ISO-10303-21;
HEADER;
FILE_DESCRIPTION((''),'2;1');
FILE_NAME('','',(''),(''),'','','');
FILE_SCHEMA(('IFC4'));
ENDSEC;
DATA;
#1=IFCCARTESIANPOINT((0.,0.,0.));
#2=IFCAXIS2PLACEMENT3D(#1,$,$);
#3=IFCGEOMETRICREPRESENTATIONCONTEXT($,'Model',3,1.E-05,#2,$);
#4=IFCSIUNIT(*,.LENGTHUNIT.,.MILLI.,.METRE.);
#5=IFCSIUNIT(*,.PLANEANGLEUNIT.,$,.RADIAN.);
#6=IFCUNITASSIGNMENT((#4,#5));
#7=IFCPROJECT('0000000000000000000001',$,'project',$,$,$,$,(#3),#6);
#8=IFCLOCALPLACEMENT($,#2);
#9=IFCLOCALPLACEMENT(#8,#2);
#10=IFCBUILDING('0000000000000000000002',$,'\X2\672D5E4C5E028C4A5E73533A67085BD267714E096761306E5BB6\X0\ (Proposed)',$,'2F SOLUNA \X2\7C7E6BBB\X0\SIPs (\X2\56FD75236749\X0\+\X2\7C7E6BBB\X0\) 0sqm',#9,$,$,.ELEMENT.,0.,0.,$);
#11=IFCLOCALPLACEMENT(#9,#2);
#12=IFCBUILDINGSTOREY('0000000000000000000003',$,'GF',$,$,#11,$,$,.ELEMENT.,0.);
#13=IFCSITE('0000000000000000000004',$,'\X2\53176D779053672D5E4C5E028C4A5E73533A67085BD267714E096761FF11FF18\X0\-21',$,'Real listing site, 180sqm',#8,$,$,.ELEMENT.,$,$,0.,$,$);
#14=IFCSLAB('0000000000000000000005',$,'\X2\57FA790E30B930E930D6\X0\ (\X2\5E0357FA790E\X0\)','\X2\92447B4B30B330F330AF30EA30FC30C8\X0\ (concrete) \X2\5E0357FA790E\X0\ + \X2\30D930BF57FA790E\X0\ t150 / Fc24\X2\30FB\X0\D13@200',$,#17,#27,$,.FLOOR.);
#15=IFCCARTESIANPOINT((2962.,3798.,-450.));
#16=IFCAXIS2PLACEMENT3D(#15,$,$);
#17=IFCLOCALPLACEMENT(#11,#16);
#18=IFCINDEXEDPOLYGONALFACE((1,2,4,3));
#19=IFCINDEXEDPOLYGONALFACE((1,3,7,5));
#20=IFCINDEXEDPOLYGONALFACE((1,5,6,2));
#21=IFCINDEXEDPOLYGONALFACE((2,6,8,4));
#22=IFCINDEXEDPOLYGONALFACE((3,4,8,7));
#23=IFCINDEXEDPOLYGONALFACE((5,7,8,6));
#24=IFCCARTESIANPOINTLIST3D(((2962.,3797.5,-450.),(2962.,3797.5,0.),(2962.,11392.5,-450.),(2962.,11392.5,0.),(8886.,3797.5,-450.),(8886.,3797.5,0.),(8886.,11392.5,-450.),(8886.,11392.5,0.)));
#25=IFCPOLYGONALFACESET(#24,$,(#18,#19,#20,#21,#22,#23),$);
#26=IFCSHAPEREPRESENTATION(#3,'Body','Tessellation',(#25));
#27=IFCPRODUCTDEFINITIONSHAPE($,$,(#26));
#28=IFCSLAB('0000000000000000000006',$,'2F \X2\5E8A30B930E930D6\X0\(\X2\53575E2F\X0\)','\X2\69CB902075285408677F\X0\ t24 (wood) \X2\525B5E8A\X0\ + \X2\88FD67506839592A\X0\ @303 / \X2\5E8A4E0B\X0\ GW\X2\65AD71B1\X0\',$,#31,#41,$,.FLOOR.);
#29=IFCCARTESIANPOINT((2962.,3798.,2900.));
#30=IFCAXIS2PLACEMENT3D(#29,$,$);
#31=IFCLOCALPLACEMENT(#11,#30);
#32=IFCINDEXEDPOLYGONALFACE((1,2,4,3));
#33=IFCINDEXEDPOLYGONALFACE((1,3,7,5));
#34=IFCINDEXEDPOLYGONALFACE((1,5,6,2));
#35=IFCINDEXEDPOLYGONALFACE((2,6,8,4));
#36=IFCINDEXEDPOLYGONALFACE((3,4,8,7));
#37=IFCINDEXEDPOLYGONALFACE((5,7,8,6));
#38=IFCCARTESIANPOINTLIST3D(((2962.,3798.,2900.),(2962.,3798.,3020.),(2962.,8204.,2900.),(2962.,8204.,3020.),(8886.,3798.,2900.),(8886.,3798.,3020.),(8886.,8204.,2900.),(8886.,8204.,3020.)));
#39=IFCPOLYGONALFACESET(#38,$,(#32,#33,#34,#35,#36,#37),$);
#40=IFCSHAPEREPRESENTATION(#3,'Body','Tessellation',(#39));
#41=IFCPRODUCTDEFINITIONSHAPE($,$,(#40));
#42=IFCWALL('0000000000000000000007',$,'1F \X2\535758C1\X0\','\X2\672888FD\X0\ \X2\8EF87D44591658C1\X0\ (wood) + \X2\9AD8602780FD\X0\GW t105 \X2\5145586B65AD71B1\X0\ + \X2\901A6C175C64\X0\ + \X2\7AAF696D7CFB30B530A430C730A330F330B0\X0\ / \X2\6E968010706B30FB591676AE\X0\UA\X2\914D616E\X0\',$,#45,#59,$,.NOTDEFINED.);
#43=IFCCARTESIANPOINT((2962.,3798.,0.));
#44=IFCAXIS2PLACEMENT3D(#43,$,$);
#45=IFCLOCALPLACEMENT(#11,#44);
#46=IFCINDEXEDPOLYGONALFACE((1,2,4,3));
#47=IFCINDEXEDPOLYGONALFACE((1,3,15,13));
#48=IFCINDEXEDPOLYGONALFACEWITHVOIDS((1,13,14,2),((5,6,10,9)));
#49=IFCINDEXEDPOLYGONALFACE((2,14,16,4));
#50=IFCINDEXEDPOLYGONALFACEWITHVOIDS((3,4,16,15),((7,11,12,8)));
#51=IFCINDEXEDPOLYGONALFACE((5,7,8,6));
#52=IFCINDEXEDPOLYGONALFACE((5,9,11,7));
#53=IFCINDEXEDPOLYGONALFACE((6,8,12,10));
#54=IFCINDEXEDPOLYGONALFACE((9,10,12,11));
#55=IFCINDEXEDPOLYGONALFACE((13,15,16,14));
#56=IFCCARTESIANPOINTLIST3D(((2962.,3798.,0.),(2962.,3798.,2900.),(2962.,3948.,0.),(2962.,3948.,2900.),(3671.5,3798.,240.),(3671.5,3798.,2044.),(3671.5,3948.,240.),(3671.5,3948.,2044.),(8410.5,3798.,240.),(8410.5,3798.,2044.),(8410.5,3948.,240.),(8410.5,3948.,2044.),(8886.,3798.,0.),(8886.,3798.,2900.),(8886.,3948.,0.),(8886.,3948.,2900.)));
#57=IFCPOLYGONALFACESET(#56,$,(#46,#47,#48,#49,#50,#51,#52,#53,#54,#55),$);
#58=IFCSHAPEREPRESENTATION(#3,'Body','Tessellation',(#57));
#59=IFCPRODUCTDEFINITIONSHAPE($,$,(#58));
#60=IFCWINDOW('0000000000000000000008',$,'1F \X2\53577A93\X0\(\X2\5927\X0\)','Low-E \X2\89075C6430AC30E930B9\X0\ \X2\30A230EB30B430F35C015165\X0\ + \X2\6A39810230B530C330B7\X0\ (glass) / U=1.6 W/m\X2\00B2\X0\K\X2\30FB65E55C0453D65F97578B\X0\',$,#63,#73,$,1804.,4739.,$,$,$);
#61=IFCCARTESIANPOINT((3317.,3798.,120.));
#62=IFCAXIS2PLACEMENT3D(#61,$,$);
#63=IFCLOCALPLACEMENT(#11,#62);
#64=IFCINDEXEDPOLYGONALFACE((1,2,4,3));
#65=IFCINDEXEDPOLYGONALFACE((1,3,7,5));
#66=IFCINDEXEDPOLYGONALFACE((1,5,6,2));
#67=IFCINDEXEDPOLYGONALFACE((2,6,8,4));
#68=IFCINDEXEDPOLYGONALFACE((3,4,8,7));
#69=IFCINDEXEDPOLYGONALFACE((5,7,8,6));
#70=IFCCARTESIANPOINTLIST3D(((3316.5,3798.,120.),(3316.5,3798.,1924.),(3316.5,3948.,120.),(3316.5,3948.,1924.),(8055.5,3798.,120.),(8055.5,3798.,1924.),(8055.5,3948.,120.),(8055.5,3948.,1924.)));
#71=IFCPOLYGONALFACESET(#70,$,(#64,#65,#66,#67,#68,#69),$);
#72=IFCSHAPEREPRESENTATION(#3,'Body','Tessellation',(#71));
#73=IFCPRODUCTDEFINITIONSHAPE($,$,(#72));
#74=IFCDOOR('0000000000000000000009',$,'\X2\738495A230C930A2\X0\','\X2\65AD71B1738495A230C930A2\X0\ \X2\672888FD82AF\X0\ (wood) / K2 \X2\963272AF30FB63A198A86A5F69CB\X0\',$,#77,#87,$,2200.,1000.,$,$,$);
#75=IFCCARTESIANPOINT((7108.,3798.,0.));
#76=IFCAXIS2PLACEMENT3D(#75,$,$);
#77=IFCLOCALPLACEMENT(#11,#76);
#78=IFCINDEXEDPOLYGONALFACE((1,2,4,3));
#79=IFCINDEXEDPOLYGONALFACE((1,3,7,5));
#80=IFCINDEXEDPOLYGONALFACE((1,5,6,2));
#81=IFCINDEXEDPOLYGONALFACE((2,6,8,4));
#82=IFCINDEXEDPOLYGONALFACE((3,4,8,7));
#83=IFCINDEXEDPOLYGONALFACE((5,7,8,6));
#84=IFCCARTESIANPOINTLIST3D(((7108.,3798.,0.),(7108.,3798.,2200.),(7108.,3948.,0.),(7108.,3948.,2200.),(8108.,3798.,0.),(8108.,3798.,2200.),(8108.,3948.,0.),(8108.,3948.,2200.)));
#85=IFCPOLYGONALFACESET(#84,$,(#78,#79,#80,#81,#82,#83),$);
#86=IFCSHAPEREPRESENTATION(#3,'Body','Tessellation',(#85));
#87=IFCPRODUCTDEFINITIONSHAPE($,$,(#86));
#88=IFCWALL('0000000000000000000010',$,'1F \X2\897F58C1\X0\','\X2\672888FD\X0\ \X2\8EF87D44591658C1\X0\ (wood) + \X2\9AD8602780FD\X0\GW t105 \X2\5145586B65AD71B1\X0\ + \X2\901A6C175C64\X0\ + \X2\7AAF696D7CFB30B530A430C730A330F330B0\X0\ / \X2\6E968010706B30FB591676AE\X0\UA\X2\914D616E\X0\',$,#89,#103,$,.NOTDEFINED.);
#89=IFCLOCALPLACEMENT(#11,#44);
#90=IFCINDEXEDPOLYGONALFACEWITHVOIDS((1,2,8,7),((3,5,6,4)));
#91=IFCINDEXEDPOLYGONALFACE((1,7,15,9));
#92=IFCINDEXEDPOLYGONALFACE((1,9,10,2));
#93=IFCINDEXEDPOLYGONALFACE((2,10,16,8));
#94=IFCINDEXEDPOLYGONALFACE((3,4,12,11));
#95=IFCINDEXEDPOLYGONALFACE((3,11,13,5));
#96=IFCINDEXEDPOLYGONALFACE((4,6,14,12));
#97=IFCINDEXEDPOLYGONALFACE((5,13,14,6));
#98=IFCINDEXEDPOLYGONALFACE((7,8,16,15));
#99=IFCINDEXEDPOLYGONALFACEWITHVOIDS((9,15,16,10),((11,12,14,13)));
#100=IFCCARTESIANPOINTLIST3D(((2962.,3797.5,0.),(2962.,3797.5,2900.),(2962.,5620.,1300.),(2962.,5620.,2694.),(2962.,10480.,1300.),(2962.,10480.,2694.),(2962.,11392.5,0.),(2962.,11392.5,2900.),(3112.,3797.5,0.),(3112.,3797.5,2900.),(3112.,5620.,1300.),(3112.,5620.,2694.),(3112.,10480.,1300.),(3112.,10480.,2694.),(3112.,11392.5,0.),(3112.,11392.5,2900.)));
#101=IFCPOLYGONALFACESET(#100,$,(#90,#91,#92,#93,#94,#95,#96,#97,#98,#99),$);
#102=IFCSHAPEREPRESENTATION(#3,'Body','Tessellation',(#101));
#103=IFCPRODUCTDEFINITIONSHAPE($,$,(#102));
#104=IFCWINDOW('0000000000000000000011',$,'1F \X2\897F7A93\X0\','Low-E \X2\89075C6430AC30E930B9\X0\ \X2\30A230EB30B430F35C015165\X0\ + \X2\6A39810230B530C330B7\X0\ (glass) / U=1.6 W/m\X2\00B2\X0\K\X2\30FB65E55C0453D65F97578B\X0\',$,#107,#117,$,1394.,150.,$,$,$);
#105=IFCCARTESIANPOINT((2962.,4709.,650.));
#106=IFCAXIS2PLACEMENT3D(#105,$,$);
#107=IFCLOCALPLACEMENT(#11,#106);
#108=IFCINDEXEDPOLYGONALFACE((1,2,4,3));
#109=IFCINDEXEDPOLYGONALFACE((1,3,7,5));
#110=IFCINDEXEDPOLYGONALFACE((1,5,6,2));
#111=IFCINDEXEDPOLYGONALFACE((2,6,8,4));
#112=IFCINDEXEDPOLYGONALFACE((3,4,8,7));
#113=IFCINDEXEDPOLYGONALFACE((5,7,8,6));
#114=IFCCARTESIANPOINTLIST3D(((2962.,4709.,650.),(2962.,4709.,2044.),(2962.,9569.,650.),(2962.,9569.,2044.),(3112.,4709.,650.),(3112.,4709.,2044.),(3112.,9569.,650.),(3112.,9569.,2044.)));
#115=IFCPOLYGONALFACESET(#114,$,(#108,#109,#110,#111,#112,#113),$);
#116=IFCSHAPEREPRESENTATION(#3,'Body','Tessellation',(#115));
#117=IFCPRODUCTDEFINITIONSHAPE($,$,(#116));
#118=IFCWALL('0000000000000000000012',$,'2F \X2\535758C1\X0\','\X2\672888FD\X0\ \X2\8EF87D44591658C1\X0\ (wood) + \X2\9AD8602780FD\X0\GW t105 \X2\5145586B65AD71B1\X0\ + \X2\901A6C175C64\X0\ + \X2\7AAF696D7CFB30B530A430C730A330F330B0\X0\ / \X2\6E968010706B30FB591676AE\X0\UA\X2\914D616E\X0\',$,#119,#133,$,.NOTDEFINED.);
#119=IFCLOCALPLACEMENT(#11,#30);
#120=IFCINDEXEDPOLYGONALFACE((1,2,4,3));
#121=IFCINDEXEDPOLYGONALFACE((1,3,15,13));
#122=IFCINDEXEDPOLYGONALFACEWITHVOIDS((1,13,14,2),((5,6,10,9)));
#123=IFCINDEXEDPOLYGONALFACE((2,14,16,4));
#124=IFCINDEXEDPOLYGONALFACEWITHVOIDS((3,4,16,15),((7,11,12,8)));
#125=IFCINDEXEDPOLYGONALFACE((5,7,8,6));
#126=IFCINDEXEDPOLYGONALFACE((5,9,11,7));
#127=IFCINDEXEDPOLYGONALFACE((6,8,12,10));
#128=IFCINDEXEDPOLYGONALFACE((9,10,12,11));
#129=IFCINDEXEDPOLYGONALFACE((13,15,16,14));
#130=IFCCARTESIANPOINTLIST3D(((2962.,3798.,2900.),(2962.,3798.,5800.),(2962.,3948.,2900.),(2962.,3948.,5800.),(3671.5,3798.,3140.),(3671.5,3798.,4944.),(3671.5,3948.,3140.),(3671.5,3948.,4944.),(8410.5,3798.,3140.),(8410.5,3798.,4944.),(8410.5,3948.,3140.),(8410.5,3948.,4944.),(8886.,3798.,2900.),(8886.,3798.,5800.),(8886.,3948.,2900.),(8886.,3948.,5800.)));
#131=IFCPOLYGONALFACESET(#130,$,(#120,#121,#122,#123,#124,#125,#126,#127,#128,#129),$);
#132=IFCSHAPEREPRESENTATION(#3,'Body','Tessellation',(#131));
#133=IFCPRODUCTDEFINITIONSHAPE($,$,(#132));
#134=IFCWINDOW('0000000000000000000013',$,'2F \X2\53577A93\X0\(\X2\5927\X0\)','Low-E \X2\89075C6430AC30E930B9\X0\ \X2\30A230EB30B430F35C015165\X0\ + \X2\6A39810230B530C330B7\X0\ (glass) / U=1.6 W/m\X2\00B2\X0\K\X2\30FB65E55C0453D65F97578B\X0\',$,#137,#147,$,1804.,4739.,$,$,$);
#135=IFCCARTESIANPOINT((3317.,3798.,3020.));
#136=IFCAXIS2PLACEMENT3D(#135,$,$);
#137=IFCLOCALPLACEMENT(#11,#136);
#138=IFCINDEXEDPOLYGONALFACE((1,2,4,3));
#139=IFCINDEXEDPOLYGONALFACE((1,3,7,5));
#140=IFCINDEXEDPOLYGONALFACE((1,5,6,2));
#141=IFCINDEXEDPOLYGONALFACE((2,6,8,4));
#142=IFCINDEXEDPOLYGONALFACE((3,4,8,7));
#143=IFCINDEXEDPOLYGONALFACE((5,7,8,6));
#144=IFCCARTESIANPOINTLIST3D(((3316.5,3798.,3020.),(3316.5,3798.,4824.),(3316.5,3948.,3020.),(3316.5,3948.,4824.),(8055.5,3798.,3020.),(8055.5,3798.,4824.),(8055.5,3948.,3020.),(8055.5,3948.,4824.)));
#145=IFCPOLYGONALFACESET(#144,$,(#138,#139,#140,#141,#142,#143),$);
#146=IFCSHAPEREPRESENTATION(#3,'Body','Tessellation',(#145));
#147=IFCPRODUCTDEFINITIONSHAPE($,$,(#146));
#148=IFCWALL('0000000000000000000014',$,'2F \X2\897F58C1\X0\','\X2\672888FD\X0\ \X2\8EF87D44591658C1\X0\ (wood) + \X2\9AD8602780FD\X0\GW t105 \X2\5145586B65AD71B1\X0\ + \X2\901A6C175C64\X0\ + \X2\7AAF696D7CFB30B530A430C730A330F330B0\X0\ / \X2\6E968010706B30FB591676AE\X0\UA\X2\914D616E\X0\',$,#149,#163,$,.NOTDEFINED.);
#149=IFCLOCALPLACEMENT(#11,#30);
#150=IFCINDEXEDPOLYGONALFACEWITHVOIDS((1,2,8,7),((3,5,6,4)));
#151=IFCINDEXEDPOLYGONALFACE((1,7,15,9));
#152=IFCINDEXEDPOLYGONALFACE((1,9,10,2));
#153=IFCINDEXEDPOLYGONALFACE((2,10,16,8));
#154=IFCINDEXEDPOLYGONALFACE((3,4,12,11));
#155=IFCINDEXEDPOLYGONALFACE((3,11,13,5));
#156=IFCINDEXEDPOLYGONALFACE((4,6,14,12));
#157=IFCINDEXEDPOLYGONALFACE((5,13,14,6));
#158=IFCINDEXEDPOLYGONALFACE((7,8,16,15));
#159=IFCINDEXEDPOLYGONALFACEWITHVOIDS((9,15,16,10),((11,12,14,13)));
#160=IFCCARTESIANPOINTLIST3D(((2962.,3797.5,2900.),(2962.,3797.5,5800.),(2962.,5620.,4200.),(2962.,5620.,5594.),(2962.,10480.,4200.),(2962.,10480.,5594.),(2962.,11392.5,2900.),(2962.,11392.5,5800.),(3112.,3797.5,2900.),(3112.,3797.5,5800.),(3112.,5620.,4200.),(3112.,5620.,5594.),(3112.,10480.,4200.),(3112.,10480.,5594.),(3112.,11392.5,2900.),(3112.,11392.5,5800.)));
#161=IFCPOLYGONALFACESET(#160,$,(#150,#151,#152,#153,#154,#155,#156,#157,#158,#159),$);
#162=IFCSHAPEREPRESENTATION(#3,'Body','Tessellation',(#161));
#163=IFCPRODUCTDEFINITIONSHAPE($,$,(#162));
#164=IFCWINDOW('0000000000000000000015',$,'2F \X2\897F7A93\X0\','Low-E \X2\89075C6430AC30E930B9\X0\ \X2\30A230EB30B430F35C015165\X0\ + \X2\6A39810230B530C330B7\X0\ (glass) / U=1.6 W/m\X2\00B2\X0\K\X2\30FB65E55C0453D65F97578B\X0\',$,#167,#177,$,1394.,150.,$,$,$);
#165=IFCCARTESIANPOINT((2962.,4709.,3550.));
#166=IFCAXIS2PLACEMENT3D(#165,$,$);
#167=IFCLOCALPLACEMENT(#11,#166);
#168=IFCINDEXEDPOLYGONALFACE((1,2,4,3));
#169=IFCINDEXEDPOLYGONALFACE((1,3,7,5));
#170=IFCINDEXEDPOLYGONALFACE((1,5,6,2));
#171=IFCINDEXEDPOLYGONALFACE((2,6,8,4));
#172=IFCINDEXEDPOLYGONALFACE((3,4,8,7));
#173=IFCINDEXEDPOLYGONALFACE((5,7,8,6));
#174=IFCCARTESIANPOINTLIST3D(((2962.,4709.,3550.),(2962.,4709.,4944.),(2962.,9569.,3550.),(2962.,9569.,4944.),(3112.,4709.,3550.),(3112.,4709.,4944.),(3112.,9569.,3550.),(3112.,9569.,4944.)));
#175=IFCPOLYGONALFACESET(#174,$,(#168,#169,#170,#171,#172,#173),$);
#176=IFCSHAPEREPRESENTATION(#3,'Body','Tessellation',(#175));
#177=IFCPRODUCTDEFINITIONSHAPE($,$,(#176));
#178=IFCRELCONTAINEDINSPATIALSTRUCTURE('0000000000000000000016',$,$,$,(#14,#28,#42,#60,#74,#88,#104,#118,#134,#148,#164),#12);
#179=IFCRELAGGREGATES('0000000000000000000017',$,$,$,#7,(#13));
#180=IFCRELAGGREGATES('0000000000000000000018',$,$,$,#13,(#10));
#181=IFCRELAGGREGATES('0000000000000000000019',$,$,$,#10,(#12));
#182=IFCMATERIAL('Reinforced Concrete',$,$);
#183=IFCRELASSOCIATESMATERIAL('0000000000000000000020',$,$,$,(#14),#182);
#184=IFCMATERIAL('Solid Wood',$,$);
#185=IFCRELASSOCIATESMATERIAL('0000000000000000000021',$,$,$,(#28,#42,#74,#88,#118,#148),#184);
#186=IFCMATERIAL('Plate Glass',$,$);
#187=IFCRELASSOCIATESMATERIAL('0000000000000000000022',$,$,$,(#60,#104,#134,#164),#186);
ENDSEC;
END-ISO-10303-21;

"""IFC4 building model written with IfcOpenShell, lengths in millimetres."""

from ifc_helpers import new_model, si_unit, frame, frame_2d, origin, place, context, project, spatial, rectangle, extrude, material, element, fill, save


model = new_model("IFC4")

# Units and contexts
model_context = context("Model", 3, precision=1e-05, world=origin())
ifc_project = project(units=[si_unit("LENGTHUNIT", "METRE", prefix="MILLI"), si_unit("PLANEANGLEUNIT", "RADIAN")], contexts=[model_context])

# Site, building, storey
site_placement = place(None, origin())
site = spatial("IfcSite", under=ifc_project, at=site_placement, Name="北海道札幌市豊平区月寒東三条１８-21", ObjectType="Real listing site, 180sqm", CompositionType="ELEMENT", RefElevation=0.0)
building_placement = place(site_placement, origin())
building = spatial("IfcBuilding", under=site, at=building_placement, Name="札幌市豊平区月寒東三条の家 (Proposed)", ObjectType="2F SOLUNA 籾殻SIPs (国産杉+籾殻) 0sqm", CompositionType="ELEMENT", ElevationOfRefHeight=0.0, ElevationOfTerrain=0.0)
storey_placement = place(building_placement, origin())
storey = spatial("IfcBuildingStorey", under=building, at=storey_placement, Name="GF", CompositionType="ELEMENT", Elevation=0.0)

# Slabs
ifc_material_1 = material(Name="Reinforced Concrete")
slab_1_placement = place(storey_placement, frame((2962.0, 3798.0, -450.0)))
element("IfcSlab", 1, at=slab_1_placement, inside=storey, material=ifc_material_1, Name="基礎スラブ (布基礎)", Description="鉄筋コンクリート (concrete) 布基礎 + ベタ基礎 t150 / Fc24・D13@200", PredefinedType="FLOOR", context=model_context, shape_type="SweptSolid", body=[
    extrude(rectangle(XDim=5924.0, YDim=7595.0, at=frame_2d((2962.0, 3797.0))), frame((2962.0, 3798.0, -450.0)), (0.0, 0.0, 1.0), 450.0),
])
ifc_material_2 = material(Name="Solid Wood")
slab_2_placement = place(storey_placement, frame((2962.0, 3798.0, 2900.0)))
element("IfcSlab", 2, at=slab_2_placement, inside=storey, material=ifc_material_2, Name="2F 床スラブ(南帯)", Description="構造用合板 t24 (wood) 剛床 + 製材根太 @303 / 床下 GW断熱", PredefinedType="FLOOR", context=model_context, shape_type="SweptSolid", body=[
    extrude(rectangle(XDim=5924.0, YDim=4406.0, at=frame_2d((2962.0, 2203.0))), frame((2962.0, 3798.0, 2900.0)), (0.0, 0.0, 1.0), 120.0),
])

# Wall, openings, window, door
wall_1_placement = place(storey_placement, frame((2962.0, 3798.0, 0.0)))
wall_1 = element("IfcWall", 3, at=wall_1_placement, inside=storey, material=ifc_material_2, Name="1F 南壁", Description="木製 軸組外壁 (wood) + 高性能GW t105 充填断熱 + 通気層 + 窯業系サイディング / 準耐火・外皮UA配慮", PredefinedType="NOTDEFINED", context=model_context, shape_type="SweptSolid", body=[
    extrude(rectangle(XDim=5924.0, YDim=150.0, at=frame_2d((2962.0, 75.0))), frame((2962.0, 3798.0, 0.0)), (0.0, 0.0, 1.0), 2900.0),
])
opening_1_placement = place(storey_placement, frame((3317.0, 3798.0, 120.0)))
opening_1 = element("IfcOpeningElement", 4, at=opening_1_placement, cuts=wall_1, PredefinedType="NOTDEFINED", context=model_context, shape_type="SweptSolid", body=[
    extrude(rectangle(XDim=4739.0, YDim=150.0, at=frame_2d((2369.0, 75.0))), frame((3317.0, 3798.0, 120.0)), (0.0, 0.0, 1.0), 1804.0),
])
opening_2_placement = place(storey_placement, frame((7108.0, 3798.0, 0.0)))
opening_2 = element("IfcOpeningElement", 5, at=opening_2_placement, cuts=wall_1, PredefinedType="NOTDEFINED", context=model_context, shape_type="SweptSolid", body=[
    extrude(rectangle(XDim=1000.0, YDim=150.0, at=frame_2d((500.0, 75.0))), frame((7108.0, 3798.0, 0.0)), (0.0, 0.0, 1.0), 2200.0),
])
ifc_material_3 = material(Name="Plate Glass")
window_1_placement = place(storey_placement, frame((3317.0, 3798.0, 120.0)))
window_1 = element("IfcWindow", 6, at=window_1_placement, inside=storey, material=ifc_material_3, Name="1F 南窓(大)", Description="Low-E 複層ガラス アルゴン封入 + 樹脂サッシ (glass) / U=1.6 W/m²K・日射取得型", OverallHeight=1804.0, OverallWidth=4739.0, context=model_context, shape_type="SweptSolid", body=[
    extrude(rectangle(XDim=4739.0, YDim=150.0, at=frame_2d((2369.0, 75.0))), frame((3317.0, 3798.0, 120.0)), (0.0, 0.0, 1.0), 1804.0),
])
fill(opening_1, window_1)
door_placement = place(storey_placement, frame((7108.0, 3798.0, 0.0)))
door = element("IfcDoor", 7, at=door_placement, inside=storey, material=ifc_material_2, Name="玄関ドア", Description="断熱玄関ドア 木製芯 (wood) / K2 防犯・採風機構", OverallHeight=2200.0, OverallWidth=1000.0, context=model_context, shape_type="SweptSolid", body=[
    extrude(rectangle(XDim=1000.0, YDim=150.0, at=frame_2d((500.0, 75.0))), frame((7108.0, 3798.0, 0.0)), (0.0, 0.0, 1.0), 2200.0),
])
fill(opening_2, door)

# Wall, opening, window
wall_2_placement = place(storey_placement, frame((2962.0, 3798.0, 0.0)))
wall_2 = element("IfcWall", 8, at=wall_2_placement, inside=storey, material=ifc_material_2, Name="1F 西壁", Description="木製 軸組外壁 (wood) + 高性能GW t105 充填断熱 + 通気層 + 窯業系サイディング / 準耐火・外皮UA配慮", PredefinedType="NOTDEFINED", context=model_context, shape_type="SweptSolid", body=[
    extrude(rectangle(XDim=150.0, YDim=7595.0, at=frame_2d((75.0, 3797.0))), frame((2962.0, 3798.0, 0.0)), (0.0, 0.0, 1.0), 2900.0),
])
opening_3_placement = place(storey_placement, frame((2962.0, 4709.0, 650.0)))
opening_3 = element("IfcOpeningElement", 9, at=opening_3_placement, cuts=wall_2, PredefinedType="NOTDEFINED", context=model_context, shape_type="SweptSolid", body=[
    extrude(rectangle(XDim=150.0, YDim=4860.0, at=frame_2d((75.0, 2430.0))), frame((2962.0, 4709.0, 650.0)), (0.0, 0.0, 1.0), 1394.0),
])
window_2_placement = place(storey_placement, frame((2962.0, 4709.0, 650.0)))
window_2 = element("IfcWindow", 10, at=window_2_placement, inside=storey, material=ifc_material_3, Name="1F 西窓", Description="Low-E 複層ガラス アルゴン封入 + 樹脂サッシ (glass) / U=1.6 W/m²K・日射取得型", OverallHeight=1394.0, OverallWidth=150.0, context=model_context, shape_type="SweptSolid", body=[
    extrude(rectangle(XDim=150.0, YDim=4860.0, at=frame_2d((75.0, 2430.0))), frame((2962.0, 4709.0, 650.0)), (0.0, 0.0, 1.0), 1394.0),
])
fill(opening_3, window_2)

# Walls, openings, windows
wall_3_placement = place(storey_placement, frame((2962.0, 3798.0, 2900.0)))
wall_3 = element("IfcWall", 11, at=wall_3_placement, inside=storey, material=ifc_material_2, Name="2F 南壁", Description="木製 軸組外壁 (wood) + 高性能GW t105 充填断熱 + 通気層 + 窯業系サイディング / 準耐火・外皮UA配慮", PredefinedType="NOTDEFINED", context=model_context, shape_type="SweptSolid", body=[
    extrude(rectangle(XDim=5924.0, YDim=150.0, at=frame_2d((2962.0, 75.0))), frame((2962.0, 3798.0, 2900.0)), (0.0, 0.0, 1.0), 2900.0),
])
opening_4_placement = place(storey_placement, frame((3317.0, 3798.0, 3020.0)))
opening_4 = element("IfcOpeningElement", 12, at=opening_4_placement, cuts=wall_3, PredefinedType="NOTDEFINED", context=model_context, shape_type="SweptSolid", body=[
    extrude(rectangle(XDim=4739.0, YDim=150.0, at=frame_2d((2369.0, 75.0))), frame((3317.0, 3798.0, 3020.0)), (0.0, 0.0, 1.0), 1804.0),
])
window_3_placement = place(storey_placement, frame((3317.0, 3798.0, 3020.0)))
window_3 = element("IfcWindow", 13, at=window_3_placement, inside=storey, material=ifc_material_3, Name="2F 南窓(大)", Description="Low-E 複層ガラス アルゴン封入 + 樹脂サッシ (glass) / U=1.6 W/m²K・日射取得型", OverallHeight=1804.0, OverallWidth=4739.0, context=model_context, shape_type="SweptSolid", body=[
    extrude(rectangle(XDim=4739.0, YDim=150.0, at=frame_2d((2369.0, 75.0))), frame((3317.0, 3798.0, 3020.0)), (0.0, 0.0, 1.0), 1804.0),
])
fill(opening_4, window_3)
wall_4_placement = place(storey_placement, frame((2962.0, 3798.0, 2900.0)))
wall_4 = element("IfcWall", 14, at=wall_4_placement, inside=storey, material=ifc_material_2, Name="2F 西壁", Description="木製 軸組外壁 (wood) + 高性能GW t105 充填断熱 + 通気層 + 窯業系サイディング / 準耐火・外皮UA配慮", PredefinedType="NOTDEFINED", context=model_context, shape_type="SweptSolid", body=[
    extrude(rectangle(XDim=150.0, YDim=7595.0, at=frame_2d((75.0, 3797.0))), frame((2962.0, 3798.0, 2900.0)), (0.0, 0.0, 1.0), 2900.0),
])
opening_5_placement = place(storey_placement, frame((2962.0, 4709.0, 3550.0)))
opening_5 = element("IfcOpeningElement", 15, at=opening_5_placement, cuts=wall_4, PredefinedType="NOTDEFINED", context=model_context, shape_type="SweptSolid", body=[
    extrude(rectangle(XDim=150.0, YDim=4860.0, at=frame_2d((75.0, 2430.0))), frame((2962.0, 4709.0, 3550.0)), (0.0, 0.0, 1.0), 1394.0),
])
window_4_placement = place(storey_placement, frame((2962.0, 4709.0, 3550.0)))
window_4 = element("IfcWindow", 16, at=window_4_placement, inside=storey, material=ifc_material_3, Name="2F 西窓", Description="Low-E 複層ガラス アルゴン封入 + 樹脂サッシ (glass) / U=1.6 W/m²K・日射取得型", OverallHeight=1394.0, OverallWidth=150.0, context=model_context, shape_type="SweptSolid", body=[
    extrude(rectangle(XDim=150.0, YDim=4860.0, at=frame_2d((75.0, 2430.0))), frame((2962.0, 4709.0, 3550.0)), (0.0, 0.0, 1.0), 1394.0),
])
fill(opening_5, window_4)

save(model, "model.ifc")
